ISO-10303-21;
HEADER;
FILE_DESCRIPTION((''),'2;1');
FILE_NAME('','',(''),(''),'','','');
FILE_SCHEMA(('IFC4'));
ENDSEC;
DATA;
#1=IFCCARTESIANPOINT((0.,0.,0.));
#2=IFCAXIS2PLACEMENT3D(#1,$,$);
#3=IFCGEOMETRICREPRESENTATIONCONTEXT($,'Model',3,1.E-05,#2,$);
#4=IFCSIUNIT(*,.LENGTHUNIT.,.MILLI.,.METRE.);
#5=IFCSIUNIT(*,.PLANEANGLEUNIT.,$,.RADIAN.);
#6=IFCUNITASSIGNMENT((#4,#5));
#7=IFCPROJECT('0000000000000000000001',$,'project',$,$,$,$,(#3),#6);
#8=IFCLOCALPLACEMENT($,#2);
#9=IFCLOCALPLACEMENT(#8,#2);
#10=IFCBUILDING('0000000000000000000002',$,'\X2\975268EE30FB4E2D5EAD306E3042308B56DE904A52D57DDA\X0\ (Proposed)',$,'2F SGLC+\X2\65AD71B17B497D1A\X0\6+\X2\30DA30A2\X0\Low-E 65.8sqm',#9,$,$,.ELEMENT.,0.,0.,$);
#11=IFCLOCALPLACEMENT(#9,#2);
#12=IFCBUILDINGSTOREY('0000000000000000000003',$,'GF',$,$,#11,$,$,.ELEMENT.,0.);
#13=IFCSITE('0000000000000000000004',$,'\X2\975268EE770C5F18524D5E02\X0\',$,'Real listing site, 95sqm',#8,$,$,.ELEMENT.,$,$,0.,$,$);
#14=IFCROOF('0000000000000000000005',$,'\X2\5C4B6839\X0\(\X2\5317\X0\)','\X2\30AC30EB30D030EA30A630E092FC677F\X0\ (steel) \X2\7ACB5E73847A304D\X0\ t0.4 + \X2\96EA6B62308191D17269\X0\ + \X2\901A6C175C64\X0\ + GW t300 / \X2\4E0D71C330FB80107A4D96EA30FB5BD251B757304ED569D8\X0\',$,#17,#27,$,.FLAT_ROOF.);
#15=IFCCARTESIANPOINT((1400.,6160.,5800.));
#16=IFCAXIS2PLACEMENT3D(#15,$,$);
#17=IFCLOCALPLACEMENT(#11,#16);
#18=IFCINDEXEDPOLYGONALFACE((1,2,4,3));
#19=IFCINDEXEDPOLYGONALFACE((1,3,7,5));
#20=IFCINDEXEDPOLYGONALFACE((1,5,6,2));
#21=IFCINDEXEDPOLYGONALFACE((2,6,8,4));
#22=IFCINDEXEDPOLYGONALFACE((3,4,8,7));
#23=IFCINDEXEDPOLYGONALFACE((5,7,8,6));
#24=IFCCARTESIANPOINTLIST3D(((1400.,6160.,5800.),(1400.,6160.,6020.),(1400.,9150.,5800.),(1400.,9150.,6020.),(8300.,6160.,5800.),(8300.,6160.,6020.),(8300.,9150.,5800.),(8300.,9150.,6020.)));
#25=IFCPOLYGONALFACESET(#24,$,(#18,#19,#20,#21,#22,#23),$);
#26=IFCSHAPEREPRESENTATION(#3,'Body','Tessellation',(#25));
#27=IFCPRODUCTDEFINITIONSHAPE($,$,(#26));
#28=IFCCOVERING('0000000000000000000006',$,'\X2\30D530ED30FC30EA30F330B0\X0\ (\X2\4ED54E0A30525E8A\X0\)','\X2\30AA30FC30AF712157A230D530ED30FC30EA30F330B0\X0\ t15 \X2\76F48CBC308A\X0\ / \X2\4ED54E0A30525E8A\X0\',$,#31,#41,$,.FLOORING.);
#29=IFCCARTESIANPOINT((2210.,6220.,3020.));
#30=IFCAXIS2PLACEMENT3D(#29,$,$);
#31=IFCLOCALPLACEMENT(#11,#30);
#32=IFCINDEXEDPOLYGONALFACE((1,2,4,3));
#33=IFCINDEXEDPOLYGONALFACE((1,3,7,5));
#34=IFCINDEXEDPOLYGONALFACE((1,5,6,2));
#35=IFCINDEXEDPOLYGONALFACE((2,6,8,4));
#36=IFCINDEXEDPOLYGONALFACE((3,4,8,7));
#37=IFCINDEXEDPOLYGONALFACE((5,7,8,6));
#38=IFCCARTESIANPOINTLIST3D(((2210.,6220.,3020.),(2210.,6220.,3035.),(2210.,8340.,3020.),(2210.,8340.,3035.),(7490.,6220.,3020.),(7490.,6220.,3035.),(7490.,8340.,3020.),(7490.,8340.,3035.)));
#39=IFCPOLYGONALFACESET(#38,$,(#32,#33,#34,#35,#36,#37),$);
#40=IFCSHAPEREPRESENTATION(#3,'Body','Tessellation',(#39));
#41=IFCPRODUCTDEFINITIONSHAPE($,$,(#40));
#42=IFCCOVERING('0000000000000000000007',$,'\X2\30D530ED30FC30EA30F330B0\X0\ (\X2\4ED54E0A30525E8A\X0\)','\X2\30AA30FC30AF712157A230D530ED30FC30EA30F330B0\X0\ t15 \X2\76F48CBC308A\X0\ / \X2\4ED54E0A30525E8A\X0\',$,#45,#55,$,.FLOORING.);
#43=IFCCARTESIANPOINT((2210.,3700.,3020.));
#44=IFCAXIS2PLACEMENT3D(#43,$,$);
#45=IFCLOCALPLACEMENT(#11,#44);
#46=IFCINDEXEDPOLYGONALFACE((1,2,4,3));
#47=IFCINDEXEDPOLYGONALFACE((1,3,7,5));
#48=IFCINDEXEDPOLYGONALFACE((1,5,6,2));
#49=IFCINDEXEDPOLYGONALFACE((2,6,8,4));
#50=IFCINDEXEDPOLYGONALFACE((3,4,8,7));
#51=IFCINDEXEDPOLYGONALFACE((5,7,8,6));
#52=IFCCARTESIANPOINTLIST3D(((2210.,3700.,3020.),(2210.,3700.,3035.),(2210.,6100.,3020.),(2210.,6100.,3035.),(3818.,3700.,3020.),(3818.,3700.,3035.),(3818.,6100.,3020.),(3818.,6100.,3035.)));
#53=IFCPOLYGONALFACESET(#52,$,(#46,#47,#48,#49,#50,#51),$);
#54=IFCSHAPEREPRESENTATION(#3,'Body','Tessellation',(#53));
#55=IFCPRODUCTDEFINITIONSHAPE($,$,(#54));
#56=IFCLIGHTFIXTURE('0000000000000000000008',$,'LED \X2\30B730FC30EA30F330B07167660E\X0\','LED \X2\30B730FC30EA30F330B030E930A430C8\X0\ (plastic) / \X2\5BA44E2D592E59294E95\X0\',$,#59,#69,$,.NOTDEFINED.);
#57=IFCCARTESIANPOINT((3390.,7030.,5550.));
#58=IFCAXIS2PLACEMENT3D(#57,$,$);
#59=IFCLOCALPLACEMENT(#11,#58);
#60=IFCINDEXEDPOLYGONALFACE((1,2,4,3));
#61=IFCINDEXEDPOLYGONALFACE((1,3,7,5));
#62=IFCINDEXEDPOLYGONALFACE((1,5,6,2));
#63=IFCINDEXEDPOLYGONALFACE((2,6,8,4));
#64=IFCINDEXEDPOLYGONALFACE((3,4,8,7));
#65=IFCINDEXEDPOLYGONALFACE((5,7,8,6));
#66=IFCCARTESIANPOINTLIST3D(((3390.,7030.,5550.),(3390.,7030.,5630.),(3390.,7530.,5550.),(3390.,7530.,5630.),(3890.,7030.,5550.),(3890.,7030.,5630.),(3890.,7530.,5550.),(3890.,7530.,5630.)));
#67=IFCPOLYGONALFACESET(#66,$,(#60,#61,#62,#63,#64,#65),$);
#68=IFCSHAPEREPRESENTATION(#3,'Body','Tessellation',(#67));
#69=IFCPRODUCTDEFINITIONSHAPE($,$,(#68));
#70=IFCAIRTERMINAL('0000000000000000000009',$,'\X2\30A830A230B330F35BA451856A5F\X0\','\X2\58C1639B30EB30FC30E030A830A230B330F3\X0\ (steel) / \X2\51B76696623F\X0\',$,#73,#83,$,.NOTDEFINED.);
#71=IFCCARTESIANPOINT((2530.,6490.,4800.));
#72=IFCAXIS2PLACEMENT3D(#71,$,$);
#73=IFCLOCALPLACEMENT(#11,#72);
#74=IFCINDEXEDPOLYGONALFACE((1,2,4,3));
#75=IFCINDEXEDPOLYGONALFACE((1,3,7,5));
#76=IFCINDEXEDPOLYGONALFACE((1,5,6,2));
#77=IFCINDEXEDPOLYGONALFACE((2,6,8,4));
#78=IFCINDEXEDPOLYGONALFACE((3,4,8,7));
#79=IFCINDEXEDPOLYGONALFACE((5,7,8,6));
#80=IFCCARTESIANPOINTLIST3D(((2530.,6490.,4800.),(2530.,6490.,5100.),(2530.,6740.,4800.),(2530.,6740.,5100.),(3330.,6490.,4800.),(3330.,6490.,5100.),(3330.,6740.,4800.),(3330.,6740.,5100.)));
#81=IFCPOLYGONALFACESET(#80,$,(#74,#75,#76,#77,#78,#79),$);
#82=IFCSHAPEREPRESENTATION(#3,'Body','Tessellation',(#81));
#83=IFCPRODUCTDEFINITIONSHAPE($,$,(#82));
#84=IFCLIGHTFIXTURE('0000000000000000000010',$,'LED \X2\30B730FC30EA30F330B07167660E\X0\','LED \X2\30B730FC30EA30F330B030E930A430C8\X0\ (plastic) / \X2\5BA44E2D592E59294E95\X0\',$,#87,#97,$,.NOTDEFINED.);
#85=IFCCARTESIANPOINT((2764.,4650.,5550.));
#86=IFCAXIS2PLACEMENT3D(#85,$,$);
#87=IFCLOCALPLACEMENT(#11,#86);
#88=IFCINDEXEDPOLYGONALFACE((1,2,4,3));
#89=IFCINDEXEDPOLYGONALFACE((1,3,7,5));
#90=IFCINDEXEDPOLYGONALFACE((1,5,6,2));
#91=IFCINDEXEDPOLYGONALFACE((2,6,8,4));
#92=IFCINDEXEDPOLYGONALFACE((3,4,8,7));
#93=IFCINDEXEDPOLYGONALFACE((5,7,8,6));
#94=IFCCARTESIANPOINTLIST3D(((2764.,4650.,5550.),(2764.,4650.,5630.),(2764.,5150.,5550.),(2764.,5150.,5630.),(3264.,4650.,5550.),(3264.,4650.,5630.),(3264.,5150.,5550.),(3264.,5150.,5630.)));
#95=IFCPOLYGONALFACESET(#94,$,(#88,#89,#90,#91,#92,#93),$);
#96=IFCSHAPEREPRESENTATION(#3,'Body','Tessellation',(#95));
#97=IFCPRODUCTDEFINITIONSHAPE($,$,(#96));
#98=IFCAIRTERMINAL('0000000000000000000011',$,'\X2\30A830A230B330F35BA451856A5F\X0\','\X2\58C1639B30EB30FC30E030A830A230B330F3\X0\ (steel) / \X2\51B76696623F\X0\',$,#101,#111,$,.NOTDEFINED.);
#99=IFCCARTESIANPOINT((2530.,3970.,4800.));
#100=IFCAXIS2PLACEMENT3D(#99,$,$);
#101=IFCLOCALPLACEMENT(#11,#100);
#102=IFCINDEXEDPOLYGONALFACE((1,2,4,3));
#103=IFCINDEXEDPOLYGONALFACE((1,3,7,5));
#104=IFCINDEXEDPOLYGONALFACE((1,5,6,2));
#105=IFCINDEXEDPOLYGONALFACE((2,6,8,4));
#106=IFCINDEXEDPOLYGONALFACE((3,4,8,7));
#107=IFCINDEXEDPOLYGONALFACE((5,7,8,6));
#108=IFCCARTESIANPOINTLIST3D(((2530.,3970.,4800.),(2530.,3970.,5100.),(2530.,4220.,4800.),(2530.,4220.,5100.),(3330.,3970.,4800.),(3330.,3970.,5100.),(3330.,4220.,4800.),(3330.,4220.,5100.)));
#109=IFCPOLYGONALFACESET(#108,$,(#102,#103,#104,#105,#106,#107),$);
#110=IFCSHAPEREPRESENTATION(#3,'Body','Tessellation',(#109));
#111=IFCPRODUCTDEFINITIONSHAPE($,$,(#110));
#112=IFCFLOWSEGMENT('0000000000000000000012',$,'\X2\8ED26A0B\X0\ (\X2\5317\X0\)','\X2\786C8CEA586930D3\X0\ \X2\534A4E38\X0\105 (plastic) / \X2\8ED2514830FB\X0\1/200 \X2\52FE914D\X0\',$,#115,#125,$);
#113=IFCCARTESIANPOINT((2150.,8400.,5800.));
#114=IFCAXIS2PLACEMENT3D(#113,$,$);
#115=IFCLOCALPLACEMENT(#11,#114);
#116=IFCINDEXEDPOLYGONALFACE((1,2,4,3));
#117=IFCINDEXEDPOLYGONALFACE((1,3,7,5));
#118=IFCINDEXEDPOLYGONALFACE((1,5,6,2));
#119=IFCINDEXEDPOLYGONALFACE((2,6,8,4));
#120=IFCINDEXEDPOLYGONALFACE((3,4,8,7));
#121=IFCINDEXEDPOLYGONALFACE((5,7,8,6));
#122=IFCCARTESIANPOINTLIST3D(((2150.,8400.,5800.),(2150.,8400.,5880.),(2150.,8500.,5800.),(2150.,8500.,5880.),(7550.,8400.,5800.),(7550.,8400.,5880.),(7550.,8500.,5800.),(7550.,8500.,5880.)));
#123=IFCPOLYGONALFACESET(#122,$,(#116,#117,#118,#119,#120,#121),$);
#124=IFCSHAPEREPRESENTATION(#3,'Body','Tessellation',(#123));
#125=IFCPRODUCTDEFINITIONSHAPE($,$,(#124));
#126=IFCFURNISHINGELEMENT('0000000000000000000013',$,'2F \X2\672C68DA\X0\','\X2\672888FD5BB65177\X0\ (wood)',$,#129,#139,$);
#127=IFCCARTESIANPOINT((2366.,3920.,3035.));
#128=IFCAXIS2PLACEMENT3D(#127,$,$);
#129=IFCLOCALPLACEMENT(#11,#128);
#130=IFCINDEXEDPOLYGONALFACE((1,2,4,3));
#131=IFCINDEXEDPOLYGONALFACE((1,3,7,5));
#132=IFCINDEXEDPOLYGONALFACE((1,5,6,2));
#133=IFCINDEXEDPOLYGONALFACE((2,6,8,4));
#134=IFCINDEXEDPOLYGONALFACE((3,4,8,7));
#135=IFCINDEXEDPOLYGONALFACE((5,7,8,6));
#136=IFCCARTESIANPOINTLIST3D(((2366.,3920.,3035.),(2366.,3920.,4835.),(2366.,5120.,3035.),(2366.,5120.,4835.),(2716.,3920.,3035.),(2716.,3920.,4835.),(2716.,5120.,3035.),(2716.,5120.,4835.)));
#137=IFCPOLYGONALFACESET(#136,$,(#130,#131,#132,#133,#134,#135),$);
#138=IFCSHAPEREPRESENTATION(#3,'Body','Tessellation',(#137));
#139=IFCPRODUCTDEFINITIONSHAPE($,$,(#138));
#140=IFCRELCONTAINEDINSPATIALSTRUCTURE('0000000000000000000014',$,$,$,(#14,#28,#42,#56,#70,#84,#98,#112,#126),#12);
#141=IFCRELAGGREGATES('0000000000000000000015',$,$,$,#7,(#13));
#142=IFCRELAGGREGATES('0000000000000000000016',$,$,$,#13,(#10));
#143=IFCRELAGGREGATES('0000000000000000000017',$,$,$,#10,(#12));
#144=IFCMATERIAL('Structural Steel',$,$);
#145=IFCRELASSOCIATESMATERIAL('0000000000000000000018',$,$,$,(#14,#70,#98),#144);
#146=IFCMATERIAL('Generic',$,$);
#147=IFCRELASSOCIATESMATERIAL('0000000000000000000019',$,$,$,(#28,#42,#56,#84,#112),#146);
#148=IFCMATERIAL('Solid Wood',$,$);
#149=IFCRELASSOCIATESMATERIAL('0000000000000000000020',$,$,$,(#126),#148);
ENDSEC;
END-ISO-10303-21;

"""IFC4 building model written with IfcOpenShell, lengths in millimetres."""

from ifc_helpers import new_model, si_unit, frame, frame_2d, origin, place, context, project, spatial, rectangle, extrude, material, element, save


model = new_model("IFC4")

# Units and contexts
model_context = context("Model", 3, precision=1e-05, world=origin())
ifc_project = project(units=[si_unit("LENGTHUNIT", "METRE", prefix="MILLI"), si_unit("PLANEANGLEUNIT", "RADIAN")], contexts=[model_context])

# Site, building, storey
site_placement = place(None, origin())
site = spatial("IfcSite", under=ifc_project, at=site_placement, Name="青森県弘前市", ObjectType="Real listing site, 95sqm", CompositionType="ELEMENT", RefElevation=0.0)
building_placement = place(site_placement, origin())
building = spatial("IfcBuilding", under=site, at=building_placement, Name="青森・中庭のある回遊動線 (Proposed)", ObjectType="2F SGLC+断熱等級6+ペアLow-E 65.8sqm", CompositionType="ELEMENT", ElevationOfRefHeight=0.0, ElevationOfTerrain=0.0)
storey_placement = place(building_placement, origin())
storey = spatial("IfcBuildingStorey", under=building, at=storey_placement, Name="GF", CompositionType="ELEMENT", Elevation=0.0)

# Shared definitions
ifc_material_1 = material(Name="Solid Wood")

# Roof
ifc_material_2 = material(Name="Structural Steel")
for number, where, name in (
    (1, (1400.0, 6160.0, 5800.0), "屋根(北)"),
):
    element("IfcRoof", number, at=place(storey_placement, frame(where)), inside=storey, material=ifc_material_2, Name=name, Description="ガルバリウム鋼板 (steel) 立平葺き t0.4 + 雪止め金物 + 通気層 + GW t300 / 不燃・耐積雪・寒冷地仕様", PredefinedType="FLAT_ROOF", context=model_context, shape_type="SweptSolid", body=[
        extrude(rectangle(XDim=6900.0, YDim=2990.0, at=frame_2d((3450.0, 1495.0))), frame((1400.0, 6160.0, 5800.0)), (0.0, 0.0, 1.0), 220.0),
    ])

# Coverings
ifc_material_3 = material(Name="Generic")
covering_1_placement = place(storey_placement, frame((2210.0, 6220.0, 3020.0)))
element("IfcCovering", 2, at=covering_1_placement, inside=storey, material=ifc_material_3, Name="フローリング (仕上げ床)", Description="オーク無垢フローリング t15 直貼り / 仕上げ床", PredefinedType="FLOORING", context=model_context, shape_type="SweptSolid", body=[
    extrude(rectangle(XDim=5280.0, YDim=2120.0, at=frame_2d((2640.0, 1060.0))), frame((2210.0, 6220.0, 3020.0)), (0.0, 0.0, 1.0), 15.0),
])
covering_2_placement = place(storey_placement, frame((2210.0, 3700.0, 3020.0)))
element("IfcCovering", 3, at=covering_2_placement, inside=storey, material=ifc_material_3, Name="フローリング (仕上げ床)", Description="オーク無垢フローリング t15 直貼り / 仕上げ床", PredefinedType="FLOORING", context=model_context, shape_type="SweptSolid", body=[
    extrude(rectangle(XDim=1608.0, YDim=2400.0, at=frame_2d((804.0, 1200.0))), frame((2210.0, 3700.0, 3020.0)), (0.0, 0.0, 1.0), 15.0),
])

# Light fixture
light_fixture_1_placement = place(storey_placement, frame((3390.0, 7030.0, 5550.0)))
element("IfcLightFixture", 4, at=light_fixture_1_placement, inside=storey, material=ifc_material_3, Name="LED シーリング照明", Description="LED シーリングライト (plastic) / 室中央天井", PredefinedType="NOTDEFINED", context=model_context, shape_type="SweptSolid", body=[
    extrude(rectangle(XDim=500.0, YDim=500.0, at=frame_2d((250.0, 250.0))), frame((3390.0, 7030.0, 5550.0)), (0.0, 0.0, 1.0), 80.0),
])

# Air terminal
air_terminal_1_placement = place(storey_placement, frame((2530.0, 6490.0, 4800.0)))
element("IfcAirTerminal", 5, at=air_terminal_1_placement, inside=storey, material=ifc_material_2, Name="エアコン室内機", Description="壁掛ルームエアコン (steel) / 冷暖房", PredefinedType="NOTDEFINED", context=model_context, shape_type="SweptSolid", body=[
    extrude(rectangle(XDim=800.0, YDim=250.0, at=frame_2d((400.0, 125.0))), frame((2530.0, 6490.0, 4800.0)), (0.0, 0.0, 1.0), 300.0),
])

# Light fixture
light_fixture_2_placement = place(storey_placement, frame((2764.0, 4650.0, 5550.0)))
element("IfcLightFixture", 6, at=light_fixture_2_placement, inside=storey, material=ifc_material_3, Name="LED シーリング照明", Description="LED シーリングライト (plastic) / 室中央天井", PredefinedType="NOTDEFINED", context=model_context, shape_type="SweptSolid", body=[
    extrude(rectangle(XDim=500.0, YDim=500.0, at=frame_2d((250.0, 250.0))), frame((2764.0, 4650.0, 5550.0)), (0.0, 0.0, 1.0), 80.0),
])

# Air terminal
air_terminal_2_placement = place(storey_placement, frame((2530.0, 3970.0, 4800.0)))
element("IfcAirTerminal", 7, at=air_terminal_2_placement, inside=storey, material=ifc_material_2, Name="エアコン室内機", Description="壁掛ルームエアコン (steel) / 冷暖房", PredefinedType="NOTDEFINED", context=model_context, shape_type="SweptSolid", body=[
    extrude(rectangle(XDim=800.0, YDim=250.0, at=frame_2d((400.0, 125.0))), frame((2530.0, 3970.0, 4800.0)), (0.0, 0.0, 1.0), 300.0),
])

# Flow segment
flow_segment_placement = place(storey_placement, frame((2150.0, 8400.0, 5800.0)))
element("IfcFlowSegment", 8, at=flow_segment_placement, inside=storey, material=ifc_material_3, Name="軒樋 (北)", Description="硬質塩ビ 半丸105 (plastic) / 軒先・1/200 勾配", context=model_context, shape_type="SweptSolid", body=[
    extrude(rectangle(XDim=5400.0, YDim=100.0, at=frame_2d((2700.0, 50.0))), frame((2150.0, 8400.0, 5800.0)), (0.0, 0.0, 1.0), 80.0),
])

# Furnishing element
furnishing_placement = place(storey_placement, frame((2366.0, 3920.0, 3035.0)))
element("IfcFurnishingElement", 9, at=furnishing_placement, inside=storey, material=ifc_material_1, Name="2F 本棚", Description="木製家具 (wood)", context=model_context, shape_type="SweptSolid", body=[
    extrude(rectangle(XDim=350.0, YDim=1200.0, at=frame_2d((175.0, 600.0))), frame((2366.0, 3920.0, 3035.0)), (0.0, 0.0, 1.0), 1800.0),
])

save(model, "model.ifc")
